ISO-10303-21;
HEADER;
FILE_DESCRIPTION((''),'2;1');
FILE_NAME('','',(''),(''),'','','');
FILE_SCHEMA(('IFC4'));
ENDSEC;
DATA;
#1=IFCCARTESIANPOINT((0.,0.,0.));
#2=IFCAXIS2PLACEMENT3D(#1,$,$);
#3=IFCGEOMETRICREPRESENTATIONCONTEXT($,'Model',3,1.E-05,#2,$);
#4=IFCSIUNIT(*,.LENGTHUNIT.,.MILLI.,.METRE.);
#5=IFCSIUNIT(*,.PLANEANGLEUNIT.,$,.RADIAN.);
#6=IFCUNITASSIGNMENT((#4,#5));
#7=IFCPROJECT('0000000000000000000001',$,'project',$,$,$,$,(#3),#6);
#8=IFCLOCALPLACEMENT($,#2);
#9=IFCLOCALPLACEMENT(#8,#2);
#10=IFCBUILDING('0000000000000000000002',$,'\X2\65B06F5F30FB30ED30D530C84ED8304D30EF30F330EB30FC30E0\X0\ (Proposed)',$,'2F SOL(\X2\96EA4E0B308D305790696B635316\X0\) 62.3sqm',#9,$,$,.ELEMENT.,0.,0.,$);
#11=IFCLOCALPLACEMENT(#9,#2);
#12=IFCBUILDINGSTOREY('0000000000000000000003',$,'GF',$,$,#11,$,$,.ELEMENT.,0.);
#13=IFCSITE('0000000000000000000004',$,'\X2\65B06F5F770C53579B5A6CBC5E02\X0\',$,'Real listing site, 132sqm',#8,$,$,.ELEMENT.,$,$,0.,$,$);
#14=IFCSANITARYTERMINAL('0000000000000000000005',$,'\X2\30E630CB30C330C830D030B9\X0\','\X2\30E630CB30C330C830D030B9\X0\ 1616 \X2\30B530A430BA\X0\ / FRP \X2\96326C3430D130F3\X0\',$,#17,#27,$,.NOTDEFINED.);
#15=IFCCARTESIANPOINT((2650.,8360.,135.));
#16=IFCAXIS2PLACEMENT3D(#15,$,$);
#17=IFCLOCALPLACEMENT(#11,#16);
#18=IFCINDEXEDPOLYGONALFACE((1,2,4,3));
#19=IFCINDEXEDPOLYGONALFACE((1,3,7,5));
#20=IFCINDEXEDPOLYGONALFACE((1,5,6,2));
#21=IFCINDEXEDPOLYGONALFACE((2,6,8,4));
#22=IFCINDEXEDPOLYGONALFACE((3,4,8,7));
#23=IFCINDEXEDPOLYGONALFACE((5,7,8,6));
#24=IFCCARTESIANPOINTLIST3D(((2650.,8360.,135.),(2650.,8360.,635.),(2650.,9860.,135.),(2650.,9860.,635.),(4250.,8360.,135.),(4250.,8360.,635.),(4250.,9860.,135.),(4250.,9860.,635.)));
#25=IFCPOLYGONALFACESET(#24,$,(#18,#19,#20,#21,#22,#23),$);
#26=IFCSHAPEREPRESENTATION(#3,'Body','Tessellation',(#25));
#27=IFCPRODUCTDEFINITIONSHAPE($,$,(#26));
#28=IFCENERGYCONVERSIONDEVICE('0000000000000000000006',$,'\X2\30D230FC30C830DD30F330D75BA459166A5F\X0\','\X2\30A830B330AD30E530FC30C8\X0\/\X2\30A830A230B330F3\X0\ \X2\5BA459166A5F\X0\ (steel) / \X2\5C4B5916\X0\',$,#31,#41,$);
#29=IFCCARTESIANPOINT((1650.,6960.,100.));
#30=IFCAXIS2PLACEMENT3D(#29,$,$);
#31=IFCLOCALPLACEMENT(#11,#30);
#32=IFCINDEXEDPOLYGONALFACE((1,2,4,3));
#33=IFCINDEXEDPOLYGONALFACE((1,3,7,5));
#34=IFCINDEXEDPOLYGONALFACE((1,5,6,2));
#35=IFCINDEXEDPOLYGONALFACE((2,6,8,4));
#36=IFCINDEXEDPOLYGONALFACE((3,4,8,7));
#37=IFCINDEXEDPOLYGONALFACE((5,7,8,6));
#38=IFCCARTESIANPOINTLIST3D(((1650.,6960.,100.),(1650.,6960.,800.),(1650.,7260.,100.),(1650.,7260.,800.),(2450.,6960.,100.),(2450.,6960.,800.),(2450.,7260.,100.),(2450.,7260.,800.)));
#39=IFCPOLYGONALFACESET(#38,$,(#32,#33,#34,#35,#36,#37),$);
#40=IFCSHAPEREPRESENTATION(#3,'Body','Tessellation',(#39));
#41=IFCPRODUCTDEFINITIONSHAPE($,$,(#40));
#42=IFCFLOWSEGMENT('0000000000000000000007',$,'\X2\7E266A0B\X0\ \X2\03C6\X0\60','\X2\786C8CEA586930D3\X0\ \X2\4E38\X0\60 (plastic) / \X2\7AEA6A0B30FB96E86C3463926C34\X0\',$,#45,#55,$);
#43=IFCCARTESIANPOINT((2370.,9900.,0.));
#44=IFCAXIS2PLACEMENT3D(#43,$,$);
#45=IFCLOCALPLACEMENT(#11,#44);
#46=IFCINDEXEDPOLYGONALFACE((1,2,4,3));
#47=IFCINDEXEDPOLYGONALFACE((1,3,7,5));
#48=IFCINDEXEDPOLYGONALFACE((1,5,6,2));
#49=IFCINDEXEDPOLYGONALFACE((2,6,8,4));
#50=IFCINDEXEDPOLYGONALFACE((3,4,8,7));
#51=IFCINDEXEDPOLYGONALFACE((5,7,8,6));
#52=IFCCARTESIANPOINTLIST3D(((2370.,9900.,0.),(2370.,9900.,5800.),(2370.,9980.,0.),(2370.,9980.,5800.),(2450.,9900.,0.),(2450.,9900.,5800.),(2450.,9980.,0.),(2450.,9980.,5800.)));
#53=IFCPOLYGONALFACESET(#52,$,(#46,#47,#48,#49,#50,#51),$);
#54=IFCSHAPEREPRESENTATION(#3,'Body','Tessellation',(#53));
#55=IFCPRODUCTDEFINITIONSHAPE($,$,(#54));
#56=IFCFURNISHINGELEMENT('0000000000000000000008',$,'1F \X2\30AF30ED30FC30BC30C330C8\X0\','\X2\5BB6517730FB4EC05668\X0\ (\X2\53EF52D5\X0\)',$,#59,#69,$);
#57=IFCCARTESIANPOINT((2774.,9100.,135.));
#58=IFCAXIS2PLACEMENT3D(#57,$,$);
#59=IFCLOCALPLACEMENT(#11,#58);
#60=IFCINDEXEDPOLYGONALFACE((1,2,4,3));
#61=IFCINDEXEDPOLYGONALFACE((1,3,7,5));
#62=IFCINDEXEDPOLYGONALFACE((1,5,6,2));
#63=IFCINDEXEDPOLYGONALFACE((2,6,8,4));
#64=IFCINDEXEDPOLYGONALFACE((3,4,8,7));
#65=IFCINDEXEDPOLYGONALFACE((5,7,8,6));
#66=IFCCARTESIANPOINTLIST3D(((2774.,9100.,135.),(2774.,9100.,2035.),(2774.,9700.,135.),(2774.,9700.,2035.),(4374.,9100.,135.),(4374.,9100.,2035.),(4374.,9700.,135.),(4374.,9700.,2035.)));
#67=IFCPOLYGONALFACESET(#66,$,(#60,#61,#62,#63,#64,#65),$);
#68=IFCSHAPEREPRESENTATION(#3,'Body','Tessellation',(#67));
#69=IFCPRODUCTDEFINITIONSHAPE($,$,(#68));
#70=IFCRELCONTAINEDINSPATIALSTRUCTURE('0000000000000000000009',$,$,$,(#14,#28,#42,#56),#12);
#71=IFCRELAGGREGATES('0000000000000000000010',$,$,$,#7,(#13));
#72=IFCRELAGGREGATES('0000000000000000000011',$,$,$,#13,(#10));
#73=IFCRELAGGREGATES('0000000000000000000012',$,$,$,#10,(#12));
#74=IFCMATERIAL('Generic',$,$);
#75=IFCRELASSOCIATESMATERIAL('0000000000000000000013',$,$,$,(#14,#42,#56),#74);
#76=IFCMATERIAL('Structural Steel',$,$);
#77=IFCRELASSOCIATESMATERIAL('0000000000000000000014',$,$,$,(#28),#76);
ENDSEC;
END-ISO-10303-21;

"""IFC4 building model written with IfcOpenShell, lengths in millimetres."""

from ifc_helpers import new_model, si_unit, frame, frame_2d, origin, place, context, project, spatial, rectangle, extrude, material, element, save


model = new_model("IFC4")

# Units and contexts
model_context = context("Model", 3, precision=1e-05, world=origin())
ifc_project = project(units=[si_unit("LENGTHUNIT", "METRE", prefix="MILLI"), si_unit("PLANEANGLEUNIT", "RADIAN")], contexts=[model_context])

# Site, building, storey
site_placement = place(None, origin())
site = spatial("IfcSite", under=ifc_project, at=site_placement, Name="新潟県南魚沼市", ObjectType="Real listing site, 132sqm", CompositionType="ELEMENT", RefElevation=0.0)
building_placement = place(site_placement, origin())
building = spatial("IfcBuilding", under=site, at=building_placement, Name="新潟・ロフト付きワンルーム (Proposed)", ObjectType="2F SOL(雪下ろし適正化) 62.3sqm", CompositionType="ELEMENT", ElevationOfRefHeight=0.0, ElevationOfTerrain=0.0)
storey_placement = place(building_placement, origin())
storey = spatial("IfcBuildingStorey", under=building, at=storey_placement, Name="GF", CompositionType="ELEMENT", Elevation=0.0)

# Shared definitions
ifc_material_1 = material(Name="Generic")

# Sanitary terminal
sanitary_terminal_placement = place(storey_placement, frame((2650.0, 8360.0, 135.0)))
element("IfcSanitaryTerminal", 1, at=sanitary_terminal_placement, inside=storey, material=ifc_material_1, Name="ユニットバス", Description="ユニットバス 1616 サイズ / FRP 防水パン", PredefinedType="NOTDEFINED", context=model_context, shape_type="SweptSolid", body=[
    extrude(rectangle(XDim=1600.0, YDim=1500.0, at=frame_2d((800.0, 750.0))), frame((2650.0, 8360.0, 135.0)), (0.0, 0.0, 1.0), 500.0),
])

# Energy conversion device
ifc_material_2 = material(Name="Structural Steel")
energy_conversion_device_placement = place(storey_placement, frame((1650.0, 6960.0, 100.0)))
element("IfcEnergyConversionDevice", 2, at=energy_conversion_device_placement, inside=storey, material=ifc_material_2, Name="ヒートポンプ室外機", Description="エコキュート/エアコン 室外機 (steel) / 屋外", context=model_context, shape_type="SweptSolid", body=[
    extrude(rectangle(XDim=800.0, YDim=300.0, at=frame_2d((400.0, 150.0))), frame((1650.0, 6960.0, 100.0)), (0.0, 0.0, 1.0), 700.0),
])

# Flow segment
flow_segment_placement = place(storey_placement, frame((2370.0, 9900.0, 0.0)))
element("IfcFlowSegment", 3, at=flow_segment_placement, inside=storey, material=ifc_material_1, Name="縦樋 φ60", Description="硬質塩ビ 丸60 (plastic) / 竪樋・雨水排水", context=model_context, shape_type="SweptSolid", body=[
    extrude(rectangle(XDim=80.0, YDim=80.0, at=frame_2d((40.0, 40.0))), frame((2370.0, 9900.0, 0.0)), (0.0, 0.0, 1.0), 5800.0),
])

# Furnishing element
furnishing_placement = place(storey_placement, frame((2774.0, 9100.0, 135.0)))
element("IfcFurnishingElement", 4, at=furnishing_placement, inside=storey, material=ifc_material_1, Name="1F クローゼット", Description="家具・什器 (可動)", context=model_context, shape_type="SweptSolid", body=[
    extrude(rectangle(XDim=1600.0, YDim=600.0, at=frame_2d((800.0, 300.0))), frame((2774.0, 9100.0, 135.0)), (0.0, 0.0, 1.0), 1900.0),
])

save(model, "model.ifc")
